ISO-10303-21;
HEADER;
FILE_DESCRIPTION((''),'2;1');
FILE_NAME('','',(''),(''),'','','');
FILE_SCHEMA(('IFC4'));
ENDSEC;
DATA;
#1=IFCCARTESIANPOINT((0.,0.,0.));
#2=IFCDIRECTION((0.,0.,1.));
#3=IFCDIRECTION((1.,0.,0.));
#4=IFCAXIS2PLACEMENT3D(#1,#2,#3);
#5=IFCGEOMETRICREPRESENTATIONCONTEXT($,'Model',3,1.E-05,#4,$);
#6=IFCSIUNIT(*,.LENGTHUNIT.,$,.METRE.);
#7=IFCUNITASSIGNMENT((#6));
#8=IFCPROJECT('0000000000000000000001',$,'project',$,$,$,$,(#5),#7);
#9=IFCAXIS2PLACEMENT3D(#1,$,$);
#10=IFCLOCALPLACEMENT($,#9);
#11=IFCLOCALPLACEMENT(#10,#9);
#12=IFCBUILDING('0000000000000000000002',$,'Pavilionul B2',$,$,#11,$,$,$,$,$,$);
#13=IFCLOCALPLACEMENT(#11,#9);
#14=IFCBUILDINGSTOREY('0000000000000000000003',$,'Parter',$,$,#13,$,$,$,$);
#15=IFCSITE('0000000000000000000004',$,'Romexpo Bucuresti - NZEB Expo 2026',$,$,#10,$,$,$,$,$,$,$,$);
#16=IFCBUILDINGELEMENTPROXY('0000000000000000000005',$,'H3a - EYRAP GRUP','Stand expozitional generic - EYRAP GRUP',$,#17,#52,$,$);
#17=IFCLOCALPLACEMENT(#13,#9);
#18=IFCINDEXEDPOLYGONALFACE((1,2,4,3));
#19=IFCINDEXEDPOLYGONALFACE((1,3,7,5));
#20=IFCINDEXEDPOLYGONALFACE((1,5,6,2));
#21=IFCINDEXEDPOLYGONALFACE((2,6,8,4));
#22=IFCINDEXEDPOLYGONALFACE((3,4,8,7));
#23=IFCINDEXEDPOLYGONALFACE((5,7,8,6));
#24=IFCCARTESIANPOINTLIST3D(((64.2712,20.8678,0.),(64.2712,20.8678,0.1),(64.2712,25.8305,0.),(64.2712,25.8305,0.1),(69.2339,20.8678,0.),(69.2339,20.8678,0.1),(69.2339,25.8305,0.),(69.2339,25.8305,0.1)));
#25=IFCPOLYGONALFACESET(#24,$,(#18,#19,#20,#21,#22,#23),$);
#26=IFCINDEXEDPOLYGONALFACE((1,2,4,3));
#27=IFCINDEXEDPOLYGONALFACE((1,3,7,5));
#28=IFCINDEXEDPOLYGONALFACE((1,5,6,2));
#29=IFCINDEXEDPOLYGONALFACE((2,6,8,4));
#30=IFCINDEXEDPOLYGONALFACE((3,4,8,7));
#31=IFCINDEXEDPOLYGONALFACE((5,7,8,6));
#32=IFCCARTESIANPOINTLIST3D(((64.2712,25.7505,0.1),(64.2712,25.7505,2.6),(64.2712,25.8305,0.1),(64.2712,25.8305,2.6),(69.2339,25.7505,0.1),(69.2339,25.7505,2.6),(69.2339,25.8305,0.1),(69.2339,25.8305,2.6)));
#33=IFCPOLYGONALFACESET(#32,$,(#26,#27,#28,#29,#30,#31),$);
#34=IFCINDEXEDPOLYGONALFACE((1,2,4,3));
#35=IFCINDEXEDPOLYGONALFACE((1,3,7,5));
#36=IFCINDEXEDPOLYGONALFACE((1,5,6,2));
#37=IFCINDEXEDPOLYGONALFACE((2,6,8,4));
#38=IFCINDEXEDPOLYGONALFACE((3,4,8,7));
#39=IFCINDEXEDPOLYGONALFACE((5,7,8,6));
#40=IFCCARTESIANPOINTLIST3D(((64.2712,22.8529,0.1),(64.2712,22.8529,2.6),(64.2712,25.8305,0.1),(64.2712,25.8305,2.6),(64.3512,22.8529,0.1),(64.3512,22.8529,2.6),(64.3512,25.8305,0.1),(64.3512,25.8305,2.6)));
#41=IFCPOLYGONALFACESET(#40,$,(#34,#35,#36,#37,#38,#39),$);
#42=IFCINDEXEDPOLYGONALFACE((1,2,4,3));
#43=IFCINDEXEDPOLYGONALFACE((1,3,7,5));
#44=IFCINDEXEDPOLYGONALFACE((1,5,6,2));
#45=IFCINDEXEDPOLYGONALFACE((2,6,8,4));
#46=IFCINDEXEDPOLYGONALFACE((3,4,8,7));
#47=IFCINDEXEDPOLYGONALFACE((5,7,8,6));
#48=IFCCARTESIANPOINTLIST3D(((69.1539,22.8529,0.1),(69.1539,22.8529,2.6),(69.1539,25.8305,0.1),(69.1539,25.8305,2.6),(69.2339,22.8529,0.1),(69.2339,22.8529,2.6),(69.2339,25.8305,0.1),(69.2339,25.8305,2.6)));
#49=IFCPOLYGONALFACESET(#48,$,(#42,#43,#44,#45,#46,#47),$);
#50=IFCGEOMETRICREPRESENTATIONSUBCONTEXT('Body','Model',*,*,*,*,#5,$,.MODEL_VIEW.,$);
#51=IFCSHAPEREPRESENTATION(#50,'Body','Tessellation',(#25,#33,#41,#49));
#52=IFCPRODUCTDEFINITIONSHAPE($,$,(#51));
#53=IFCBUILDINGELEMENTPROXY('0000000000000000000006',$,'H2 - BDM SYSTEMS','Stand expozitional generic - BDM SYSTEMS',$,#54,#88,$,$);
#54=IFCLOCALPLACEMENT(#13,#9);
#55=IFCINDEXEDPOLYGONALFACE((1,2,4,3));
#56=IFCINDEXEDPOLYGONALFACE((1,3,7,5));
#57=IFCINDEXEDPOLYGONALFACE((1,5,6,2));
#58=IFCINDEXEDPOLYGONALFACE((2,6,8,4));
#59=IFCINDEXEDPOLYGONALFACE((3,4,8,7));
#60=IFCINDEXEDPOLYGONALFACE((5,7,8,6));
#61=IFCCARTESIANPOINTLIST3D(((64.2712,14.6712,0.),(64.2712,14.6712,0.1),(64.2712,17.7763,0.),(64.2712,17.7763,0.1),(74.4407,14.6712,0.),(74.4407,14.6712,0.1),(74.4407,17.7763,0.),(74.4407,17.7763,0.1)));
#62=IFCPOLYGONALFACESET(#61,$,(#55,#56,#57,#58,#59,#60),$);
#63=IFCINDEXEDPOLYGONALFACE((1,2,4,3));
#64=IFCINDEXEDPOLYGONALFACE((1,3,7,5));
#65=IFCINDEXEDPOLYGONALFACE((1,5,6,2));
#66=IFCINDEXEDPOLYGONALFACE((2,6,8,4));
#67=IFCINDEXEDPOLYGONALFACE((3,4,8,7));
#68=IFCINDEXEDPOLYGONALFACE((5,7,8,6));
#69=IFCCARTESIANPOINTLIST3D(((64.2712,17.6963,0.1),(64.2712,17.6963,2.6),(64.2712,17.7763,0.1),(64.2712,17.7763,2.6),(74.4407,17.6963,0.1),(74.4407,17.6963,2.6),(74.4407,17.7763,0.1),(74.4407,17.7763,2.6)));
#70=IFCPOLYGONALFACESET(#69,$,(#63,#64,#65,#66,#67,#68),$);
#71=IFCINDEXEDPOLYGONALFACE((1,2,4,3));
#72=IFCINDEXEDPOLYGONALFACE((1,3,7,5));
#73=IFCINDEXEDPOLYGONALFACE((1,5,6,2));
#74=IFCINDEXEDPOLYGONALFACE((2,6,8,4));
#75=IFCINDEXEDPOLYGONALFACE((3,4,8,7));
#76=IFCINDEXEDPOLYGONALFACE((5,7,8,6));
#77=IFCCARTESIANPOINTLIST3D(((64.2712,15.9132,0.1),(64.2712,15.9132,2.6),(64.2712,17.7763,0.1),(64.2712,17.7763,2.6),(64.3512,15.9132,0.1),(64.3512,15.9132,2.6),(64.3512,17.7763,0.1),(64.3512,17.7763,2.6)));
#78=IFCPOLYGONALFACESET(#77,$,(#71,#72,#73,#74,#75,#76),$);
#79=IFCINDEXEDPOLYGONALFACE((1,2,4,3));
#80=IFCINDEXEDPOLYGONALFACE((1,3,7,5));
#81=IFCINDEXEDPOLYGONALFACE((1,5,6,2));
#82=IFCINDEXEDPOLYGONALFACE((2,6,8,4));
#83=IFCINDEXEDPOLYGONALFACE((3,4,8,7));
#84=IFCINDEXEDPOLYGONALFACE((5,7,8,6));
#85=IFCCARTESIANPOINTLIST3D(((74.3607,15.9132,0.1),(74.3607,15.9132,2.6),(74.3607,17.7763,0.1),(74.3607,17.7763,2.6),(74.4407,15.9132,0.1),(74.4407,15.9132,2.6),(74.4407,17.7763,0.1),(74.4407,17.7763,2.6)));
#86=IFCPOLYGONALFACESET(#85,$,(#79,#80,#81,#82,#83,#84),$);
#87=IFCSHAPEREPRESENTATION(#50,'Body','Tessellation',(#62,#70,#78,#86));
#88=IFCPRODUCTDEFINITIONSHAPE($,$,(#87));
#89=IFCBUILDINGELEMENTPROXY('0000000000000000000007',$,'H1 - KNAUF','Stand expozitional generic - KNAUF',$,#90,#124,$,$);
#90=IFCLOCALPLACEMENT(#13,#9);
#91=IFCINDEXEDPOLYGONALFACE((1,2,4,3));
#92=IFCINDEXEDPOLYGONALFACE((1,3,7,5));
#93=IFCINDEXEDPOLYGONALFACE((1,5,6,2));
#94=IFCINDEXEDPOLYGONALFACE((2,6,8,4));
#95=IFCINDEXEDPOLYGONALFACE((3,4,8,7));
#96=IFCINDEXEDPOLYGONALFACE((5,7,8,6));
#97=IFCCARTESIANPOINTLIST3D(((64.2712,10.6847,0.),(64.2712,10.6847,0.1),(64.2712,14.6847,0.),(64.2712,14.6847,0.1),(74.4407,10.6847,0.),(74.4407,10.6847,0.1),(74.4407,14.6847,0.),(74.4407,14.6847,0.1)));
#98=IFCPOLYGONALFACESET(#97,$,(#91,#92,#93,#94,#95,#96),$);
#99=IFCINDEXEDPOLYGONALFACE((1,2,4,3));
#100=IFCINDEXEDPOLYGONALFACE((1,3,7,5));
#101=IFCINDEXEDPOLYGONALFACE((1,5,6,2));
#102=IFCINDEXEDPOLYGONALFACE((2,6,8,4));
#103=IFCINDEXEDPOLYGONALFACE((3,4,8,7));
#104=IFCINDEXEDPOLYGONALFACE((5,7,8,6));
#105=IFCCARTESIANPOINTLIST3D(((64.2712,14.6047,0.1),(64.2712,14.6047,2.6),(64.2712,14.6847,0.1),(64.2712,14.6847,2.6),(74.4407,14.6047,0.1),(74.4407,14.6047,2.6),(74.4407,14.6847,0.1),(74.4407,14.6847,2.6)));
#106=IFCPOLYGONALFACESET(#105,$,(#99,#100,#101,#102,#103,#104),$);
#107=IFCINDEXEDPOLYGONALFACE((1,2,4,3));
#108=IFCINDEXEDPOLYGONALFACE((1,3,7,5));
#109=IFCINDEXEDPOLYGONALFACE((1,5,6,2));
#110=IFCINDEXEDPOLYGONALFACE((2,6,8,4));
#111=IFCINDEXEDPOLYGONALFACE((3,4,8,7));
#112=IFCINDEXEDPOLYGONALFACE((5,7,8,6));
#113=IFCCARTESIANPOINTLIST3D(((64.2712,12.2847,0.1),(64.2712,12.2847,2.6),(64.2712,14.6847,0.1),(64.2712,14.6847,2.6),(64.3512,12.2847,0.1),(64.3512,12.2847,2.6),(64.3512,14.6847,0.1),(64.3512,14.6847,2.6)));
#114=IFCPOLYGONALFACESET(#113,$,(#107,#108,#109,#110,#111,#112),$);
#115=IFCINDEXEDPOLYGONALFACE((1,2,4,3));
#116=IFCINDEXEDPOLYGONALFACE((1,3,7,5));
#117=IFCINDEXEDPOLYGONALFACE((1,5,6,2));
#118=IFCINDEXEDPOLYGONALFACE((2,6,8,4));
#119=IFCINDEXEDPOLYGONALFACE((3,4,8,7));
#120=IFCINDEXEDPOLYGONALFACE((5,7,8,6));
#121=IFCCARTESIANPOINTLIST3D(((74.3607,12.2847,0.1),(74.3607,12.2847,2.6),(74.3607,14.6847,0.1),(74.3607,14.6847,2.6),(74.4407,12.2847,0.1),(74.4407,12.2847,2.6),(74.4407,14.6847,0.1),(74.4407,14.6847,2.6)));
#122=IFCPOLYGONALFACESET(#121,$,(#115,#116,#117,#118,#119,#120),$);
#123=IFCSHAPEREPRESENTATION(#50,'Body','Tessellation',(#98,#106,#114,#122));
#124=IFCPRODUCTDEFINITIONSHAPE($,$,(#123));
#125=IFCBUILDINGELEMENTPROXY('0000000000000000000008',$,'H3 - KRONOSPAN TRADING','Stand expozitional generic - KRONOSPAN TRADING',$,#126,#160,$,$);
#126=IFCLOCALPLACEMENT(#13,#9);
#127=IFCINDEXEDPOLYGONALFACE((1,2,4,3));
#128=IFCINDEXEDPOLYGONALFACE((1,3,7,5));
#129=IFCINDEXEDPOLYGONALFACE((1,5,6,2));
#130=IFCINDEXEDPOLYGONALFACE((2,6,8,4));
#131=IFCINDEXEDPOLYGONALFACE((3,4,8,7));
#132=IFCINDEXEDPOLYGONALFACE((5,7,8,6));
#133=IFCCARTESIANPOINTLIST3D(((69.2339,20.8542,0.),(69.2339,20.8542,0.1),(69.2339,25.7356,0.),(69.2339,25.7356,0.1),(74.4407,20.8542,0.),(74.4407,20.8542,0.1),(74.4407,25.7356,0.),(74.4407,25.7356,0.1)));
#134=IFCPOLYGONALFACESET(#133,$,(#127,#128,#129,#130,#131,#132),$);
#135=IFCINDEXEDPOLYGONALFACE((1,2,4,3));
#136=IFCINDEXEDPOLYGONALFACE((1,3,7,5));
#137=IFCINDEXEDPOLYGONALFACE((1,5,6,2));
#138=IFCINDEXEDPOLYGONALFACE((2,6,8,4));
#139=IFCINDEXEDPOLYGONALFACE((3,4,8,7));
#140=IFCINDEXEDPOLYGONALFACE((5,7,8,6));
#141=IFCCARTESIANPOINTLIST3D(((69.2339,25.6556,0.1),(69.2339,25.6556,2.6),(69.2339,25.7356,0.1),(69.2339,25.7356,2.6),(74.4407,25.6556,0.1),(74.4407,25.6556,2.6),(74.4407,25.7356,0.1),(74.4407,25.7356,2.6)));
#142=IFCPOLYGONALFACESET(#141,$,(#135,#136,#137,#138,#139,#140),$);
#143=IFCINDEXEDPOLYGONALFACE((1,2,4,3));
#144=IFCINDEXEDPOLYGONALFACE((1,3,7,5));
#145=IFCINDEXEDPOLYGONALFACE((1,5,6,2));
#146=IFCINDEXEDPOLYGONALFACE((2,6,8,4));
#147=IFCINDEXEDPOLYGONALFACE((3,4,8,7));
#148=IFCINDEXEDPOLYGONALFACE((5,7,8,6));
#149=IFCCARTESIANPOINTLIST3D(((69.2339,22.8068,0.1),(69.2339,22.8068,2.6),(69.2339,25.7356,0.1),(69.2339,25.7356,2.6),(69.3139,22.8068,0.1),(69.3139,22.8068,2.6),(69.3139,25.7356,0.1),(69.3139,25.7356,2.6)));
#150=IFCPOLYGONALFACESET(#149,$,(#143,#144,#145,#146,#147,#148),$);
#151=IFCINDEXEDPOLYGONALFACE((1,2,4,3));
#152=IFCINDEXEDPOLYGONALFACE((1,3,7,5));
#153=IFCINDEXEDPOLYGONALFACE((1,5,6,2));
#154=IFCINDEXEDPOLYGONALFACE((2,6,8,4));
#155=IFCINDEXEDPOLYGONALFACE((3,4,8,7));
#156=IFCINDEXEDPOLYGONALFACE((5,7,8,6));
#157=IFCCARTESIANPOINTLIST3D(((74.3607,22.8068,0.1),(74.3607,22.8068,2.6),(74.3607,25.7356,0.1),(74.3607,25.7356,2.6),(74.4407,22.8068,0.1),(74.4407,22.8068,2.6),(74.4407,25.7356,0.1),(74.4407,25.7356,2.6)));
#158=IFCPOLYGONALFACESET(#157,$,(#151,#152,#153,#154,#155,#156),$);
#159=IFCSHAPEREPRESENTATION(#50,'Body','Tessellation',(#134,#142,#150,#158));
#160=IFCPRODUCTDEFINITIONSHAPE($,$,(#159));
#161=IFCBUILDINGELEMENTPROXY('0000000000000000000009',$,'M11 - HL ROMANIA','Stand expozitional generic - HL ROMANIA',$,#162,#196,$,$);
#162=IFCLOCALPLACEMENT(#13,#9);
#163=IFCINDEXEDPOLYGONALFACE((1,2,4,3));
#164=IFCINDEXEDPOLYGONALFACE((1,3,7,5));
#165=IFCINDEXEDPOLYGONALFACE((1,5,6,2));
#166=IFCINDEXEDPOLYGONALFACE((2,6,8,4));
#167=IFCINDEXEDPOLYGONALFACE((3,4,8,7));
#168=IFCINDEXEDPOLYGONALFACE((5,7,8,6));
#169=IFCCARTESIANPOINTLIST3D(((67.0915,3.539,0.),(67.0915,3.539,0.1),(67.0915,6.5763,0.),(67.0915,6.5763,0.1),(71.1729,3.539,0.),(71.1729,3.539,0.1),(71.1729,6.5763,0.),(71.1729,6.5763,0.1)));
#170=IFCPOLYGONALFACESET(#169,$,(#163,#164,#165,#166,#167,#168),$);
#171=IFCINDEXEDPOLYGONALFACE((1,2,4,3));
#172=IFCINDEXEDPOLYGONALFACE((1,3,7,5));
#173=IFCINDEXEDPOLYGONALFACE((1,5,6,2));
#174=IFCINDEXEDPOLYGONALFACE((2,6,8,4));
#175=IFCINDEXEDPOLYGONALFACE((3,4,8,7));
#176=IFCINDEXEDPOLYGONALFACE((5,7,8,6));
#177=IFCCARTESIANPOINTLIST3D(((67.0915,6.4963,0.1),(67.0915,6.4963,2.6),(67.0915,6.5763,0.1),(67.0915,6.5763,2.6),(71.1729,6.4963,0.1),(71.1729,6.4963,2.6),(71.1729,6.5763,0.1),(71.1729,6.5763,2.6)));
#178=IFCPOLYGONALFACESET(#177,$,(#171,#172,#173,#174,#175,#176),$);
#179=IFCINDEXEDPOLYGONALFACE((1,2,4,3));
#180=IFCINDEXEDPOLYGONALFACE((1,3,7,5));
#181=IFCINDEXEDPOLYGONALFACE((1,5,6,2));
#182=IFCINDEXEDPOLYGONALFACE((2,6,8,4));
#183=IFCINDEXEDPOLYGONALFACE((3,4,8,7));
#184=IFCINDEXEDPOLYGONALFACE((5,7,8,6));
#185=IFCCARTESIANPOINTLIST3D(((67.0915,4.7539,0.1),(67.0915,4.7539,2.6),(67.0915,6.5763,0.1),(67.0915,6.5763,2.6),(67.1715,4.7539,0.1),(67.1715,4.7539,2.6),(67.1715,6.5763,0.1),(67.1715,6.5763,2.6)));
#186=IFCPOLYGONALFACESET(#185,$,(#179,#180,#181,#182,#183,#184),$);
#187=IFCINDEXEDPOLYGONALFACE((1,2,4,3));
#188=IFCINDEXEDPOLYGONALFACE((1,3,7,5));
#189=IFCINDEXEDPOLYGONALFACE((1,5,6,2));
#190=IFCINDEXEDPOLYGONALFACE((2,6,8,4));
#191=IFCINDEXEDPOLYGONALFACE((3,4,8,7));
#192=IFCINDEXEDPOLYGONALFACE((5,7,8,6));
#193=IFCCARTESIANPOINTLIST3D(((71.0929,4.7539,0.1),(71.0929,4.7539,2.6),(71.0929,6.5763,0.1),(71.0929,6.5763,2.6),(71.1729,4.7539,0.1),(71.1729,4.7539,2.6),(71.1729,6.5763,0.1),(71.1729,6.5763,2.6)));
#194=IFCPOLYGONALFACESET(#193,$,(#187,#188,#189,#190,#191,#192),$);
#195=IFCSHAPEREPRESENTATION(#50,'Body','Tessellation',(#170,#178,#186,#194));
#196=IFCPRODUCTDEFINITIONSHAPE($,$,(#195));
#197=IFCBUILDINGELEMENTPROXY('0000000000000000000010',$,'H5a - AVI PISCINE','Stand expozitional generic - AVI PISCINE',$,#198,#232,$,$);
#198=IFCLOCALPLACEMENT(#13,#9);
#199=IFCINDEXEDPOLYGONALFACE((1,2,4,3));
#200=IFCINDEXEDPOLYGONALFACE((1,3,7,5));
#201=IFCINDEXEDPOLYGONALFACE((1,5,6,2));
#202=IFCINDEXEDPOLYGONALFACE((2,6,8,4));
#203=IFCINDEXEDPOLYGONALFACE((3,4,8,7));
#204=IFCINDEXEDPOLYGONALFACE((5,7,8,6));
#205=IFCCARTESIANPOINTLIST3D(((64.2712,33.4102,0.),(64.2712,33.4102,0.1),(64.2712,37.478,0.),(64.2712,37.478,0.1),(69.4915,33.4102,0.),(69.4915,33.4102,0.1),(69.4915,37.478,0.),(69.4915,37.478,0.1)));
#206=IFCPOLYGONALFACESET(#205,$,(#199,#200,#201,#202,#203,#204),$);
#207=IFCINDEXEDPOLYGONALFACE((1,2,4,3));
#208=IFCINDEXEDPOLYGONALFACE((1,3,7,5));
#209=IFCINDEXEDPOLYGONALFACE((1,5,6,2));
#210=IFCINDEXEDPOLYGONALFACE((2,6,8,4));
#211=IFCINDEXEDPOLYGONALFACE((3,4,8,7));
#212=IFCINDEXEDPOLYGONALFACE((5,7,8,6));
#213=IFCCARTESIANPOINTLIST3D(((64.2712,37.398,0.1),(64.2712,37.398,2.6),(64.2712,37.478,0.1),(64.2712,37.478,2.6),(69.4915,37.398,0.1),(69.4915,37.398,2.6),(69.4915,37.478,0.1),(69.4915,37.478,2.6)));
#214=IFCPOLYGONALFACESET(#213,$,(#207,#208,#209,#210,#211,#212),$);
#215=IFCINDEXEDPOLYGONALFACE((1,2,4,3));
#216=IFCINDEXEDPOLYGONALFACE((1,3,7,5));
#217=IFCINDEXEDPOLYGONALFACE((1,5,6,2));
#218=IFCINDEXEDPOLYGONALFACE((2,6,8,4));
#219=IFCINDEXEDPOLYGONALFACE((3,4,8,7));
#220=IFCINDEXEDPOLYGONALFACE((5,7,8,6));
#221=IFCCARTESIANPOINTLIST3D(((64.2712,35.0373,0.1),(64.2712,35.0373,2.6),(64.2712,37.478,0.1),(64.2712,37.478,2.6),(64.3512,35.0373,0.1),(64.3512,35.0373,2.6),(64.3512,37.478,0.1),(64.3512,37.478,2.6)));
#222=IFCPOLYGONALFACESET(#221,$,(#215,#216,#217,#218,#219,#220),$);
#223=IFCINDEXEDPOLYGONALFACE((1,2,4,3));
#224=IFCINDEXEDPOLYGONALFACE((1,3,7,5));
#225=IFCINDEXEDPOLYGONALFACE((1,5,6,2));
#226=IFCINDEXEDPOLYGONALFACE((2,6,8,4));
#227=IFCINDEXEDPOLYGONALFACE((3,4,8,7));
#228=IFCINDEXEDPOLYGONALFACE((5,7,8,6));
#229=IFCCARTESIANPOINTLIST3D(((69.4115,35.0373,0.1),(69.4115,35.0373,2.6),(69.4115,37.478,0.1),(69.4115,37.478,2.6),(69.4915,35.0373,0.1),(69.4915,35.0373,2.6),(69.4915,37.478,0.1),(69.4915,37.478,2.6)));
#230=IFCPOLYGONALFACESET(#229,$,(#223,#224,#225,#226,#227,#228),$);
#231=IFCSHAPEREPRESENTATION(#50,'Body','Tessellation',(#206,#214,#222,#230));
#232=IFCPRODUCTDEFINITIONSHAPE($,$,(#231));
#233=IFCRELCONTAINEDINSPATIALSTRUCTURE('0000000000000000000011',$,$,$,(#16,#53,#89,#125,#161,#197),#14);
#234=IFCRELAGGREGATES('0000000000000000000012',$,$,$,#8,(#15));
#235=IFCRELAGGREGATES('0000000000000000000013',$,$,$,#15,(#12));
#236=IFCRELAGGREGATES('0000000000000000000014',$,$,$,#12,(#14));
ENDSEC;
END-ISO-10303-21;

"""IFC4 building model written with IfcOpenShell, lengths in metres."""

from ifc_helpers import new_model, si_unit, frame, frame_2d, origin, origin_with_axes, place, context, subcontext, project, spatial, rectangle, extrude, element, save


model = new_model("IFC4")

# Units and contexts
model_context = context("Model", 3, precision=1e-05, world=origin_with_axes())
body_context = subcontext(model_context, "Body", "Model", "MODEL_VIEW")
ifc_project = project(units=[si_unit("LENGTHUNIT", "METRE")], contexts=[model_context])

# Site, building, storey
site_placement = place(None, origin())
site = spatial("IfcSite", under=ifc_project, at=site_placement, Name="Romexpo Bucuresti - NZEB Expo 2026")
building_placement = place(site_placement, origin())
building = spatial("IfcBuilding", under=site, at=building_placement, Name="Pavilionul B2")
storey_placement = place(building_placement, origin())
storey = spatial("IfcBuildingStorey", under=building, at=storey_placement, Name="Parter")

# Building element proxies
proxy_1_placement = place(storey_placement, frame((64.2712, 20.8678, 0.0), z_axis=(0.0, 0.0, 1.0), x_axis=(1.0, 0.0, 0.0)))
element("IfcBuildingElementProxy", 1, at=proxy_1_placement, inside=storey, Name="H3a - EYRAP GRUP", Description="Stand expozitional generic - EYRAP GRUP", context=body_context, shape_type="SweptSolid", body=[
    extrude(rectangle(XDim=4.9627, YDim=4.9627, at=frame_2d((2.4814, 2.4814))), origin(), (0.0, 0.0, 1.0), 0.1),
    extrude(rectangle(XDim=4.9627, YDim=0.08, at=frame_2d((2.4814, 4.9227))), frame((0.0, 0.0, 0.1)), (0.0, 0.0, 1.0), 2.5),
    extrude(rectangle(XDim=0.08, YDim=2.9776, at=frame_2d((0.04, 3.4739))), frame((0.0, 0.0, 0.1)), (0.0, 0.0, 1.0), 2.5),
    extrude(rectangle(XDim=0.08, YDim=2.9776, at=frame_2d((4.9227, 3.4739))), frame((0.0, 0.0, 0.1)), (0.0, 0.0, 1.0), 2.5),
])
proxy_2_placement = place(storey_placement, frame((64.2712, 14.6712, 0.0), z_axis=(0.0, 0.0, 1.0), x_axis=(1.0, 0.0, 0.0)))
element("IfcBuildingElementProxy", 2, at=proxy_2_placement, inside=storey, Name="H2 - BDM SYSTEMS", Description="Stand expozitional generic - BDM SYSTEMS", context=body_context, shape_type="SweptSolid", body=[
    extrude(rectangle(XDim=10.1695, YDim=3.1051, at=frame_2d((5.0847, 1.5525))), origin(), (0.0, 0.0, 1.0), 0.1),
    extrude(rectangle(XDim=10.1695, YDim=0.08, at=frame_2d((5.0847, 3.0651))), frame((0.0, 0.0, 0.1)), (0.0, 0.0, 1.0), 2.5),
    extrude(rectangle(XDim=0.08, YDim=1.8631, at=frame_2d((0.04, 2.1736))), frame((0.0, 0.0, 0.1)), (0.0, 0.0, 1.0), 2.5),
    extrude(rectangle(XDim=0.08, YDim=1.8631, at=frame_2d((10.1295, 2.1736))), frame((0.0, 0.0, 0.1)), (0.0, 0.0, 1.0), 2.5),
])
proxy_3_placement = place(storey_placement, frame((64.2712, 10.6847, 0.0), z_axis=(0.0, 0.0, 1.0), x_axis=(1.0, 0.0, 0.0)))
element("IfcBuildingElementProxy", 3, at=proxy_3_placement, inside=storey, Name="H1 - KNAUF", Description="Stand expozitional generic - KNAUF", context=body_context, shape_type="SweptSolid", body=[
    extrude(rectangle(XDim=10.1695, YDim=4.0, at=frame_2d((5.0847, 2.0))), origin(), (0.0, 0.0, 1.0), 0.1),
    extrude(rectangle(XDim=10.1695, YDim=0.08, at=frame_2d((5.0847, 3.96))), frame((0.0, 0.0, 0.1)), (0.0, 0.0, 1.0), 2.5),
    extrude(rectangle(XDim=0.08, YDim=2.4, at=frame_2d((0.04, 2.8))), frame((0.0, 0.0, 0.1)), (0.0, 0.0, 1.0), 2.5),
    extrude(rectangle(XDim=0.08, YDim=2.4, at=frame_2d((10.1295, 2.8))), frame((0.0, 0.0, 0.1)), (0.0, 0.0, 1.0), 2.5),
])
proxy_4_placement = place(storey_placement, frame((69.2339, 20.8542, 0.0), z_axis=(0.0, 0.0, 1.0), x_axis=(1.0, 0.0, 0.0)))
element("IfcBuildingElementProxy", 4, at=proxy_4_placement, inside=storey, Name="H3 - KRONOSPAN TRADING", Description="Stand expozitional generic - KRONOSPAN TRADING", context=body_context, shape_type="SweptSolid", body=[
    extrude(rectangle(XDim=5.2068, YDim=4.8814, at=frame_2d((2.6034, 2.4407))), origin(), (0.0, 0.0, 1.0), 0.1),
    extrude(rectangle(XDim=5.2068, YDim=0.08, at=frame_2d((2.6034, 4.8414))), frame((0.0, 0.0, 0.1)), (0.0, 0.0, 1.0), 2.5),
    extrude(rectangle(XDim=0.08, YDim=2.9288, at=frame_2d((0.04, 3.4169))), frame((0.0, 0.0, 0.1)), (0.0, 0.0, 1.0), 2.5),
    extrude(rectangle(XDim=0.08, YDim=2.9288, at=frame_2d((5.1668, 3.4169))), frame((0.0, 0.0, 0.1)), (0.0, 0.0, 1.0), 2.5),
])
proxy_5_placement = place(storey_placement, frame((67.0915, 3.539, 0.0), z_axis=(0.0, 0.0, 1.0), x_axis=(1.0, 0.0, 0.0)))
element("IfcBuildingElementProxy", 5, at=proxy_5_placement, inside=storey, Name="M11 - HL ROMANIA", Description="Stand expozitional generic - HL ROMANIA", context=body_context, shape_type="SweptSolid", body=[
    extrude(rectangle(XDim=4.0814, YDim=3.0373, at=frame_2d((2.0407, 1.5186))), origin(), (0.0, 0.0, 1.0), 0.1),
    extrude(rectangle(XDim=4.0814, YDim=0.08, at=frame_2d((2.0407, 2.9973))), frame((0.0, 0.0, 0.1)), (0.0, 0.0, 1.0), 2.5),
    extrude(rectangle(XDim=0.08, YDim=1.8224, at=frame_2d((0.04, 2.1261))), frame((0.0, 0.0, 0.1)), (0.0, 0.0, 1.0), 2.5),
    extrude(rectangle(XDim=0.08, YDim=1.8224, at=frame_2d((4.0414, 2.1261))), frame((0.0, 0.0, 0.1)), (0.0, 0.0, 1.0), 2.5),
])
proxy_6_placement = place(storey_placement, frame((64.2712, 33.4102, 0.0), z_axis=(0.0, 0.0, 1.0), x_axis=(1.0, 0.0, 0.0)))
element("IfcBuildingElementProxy", 6, at=proxy_6_placement, inside=storey, Name="H5a - AVI PISCINE", Description="Stand expozitional generic - AVI PISCINE", context=body_context, shape_type="SweptSolid", body=[
    extrude(rectangle(XDim=5.2203, YDim=4.0678, at=frame_2d((2.6102, 2.0339))), origin(), (0.0, 0.0, 1.0), 0.1),
    extrude(rectangle(XDim=5.2203, YDim=0.08, at=frame_2d((2.6102, 4.0278))), frame((0.0, 0.0, 0.1)), (0.0, 0.0, 1.0), 2.5),
    extrude(rectangle(XDim=0.08, YDim=2.4407, at=frame_2d((0.04, 2.8475))), frame((0.0, 0.0, 0.1)), (0.0, 0.0, 1.0), 2.5),
    extrude(rectangle(XDim=0.08, YDim=2.4407, at=frame_2d((5.1803, 2.8475))), frame((0.0, 0.0, 0.1)), (0.0, 0.0, 1.0), 2.5),
])

save(model, "model.ifc")
